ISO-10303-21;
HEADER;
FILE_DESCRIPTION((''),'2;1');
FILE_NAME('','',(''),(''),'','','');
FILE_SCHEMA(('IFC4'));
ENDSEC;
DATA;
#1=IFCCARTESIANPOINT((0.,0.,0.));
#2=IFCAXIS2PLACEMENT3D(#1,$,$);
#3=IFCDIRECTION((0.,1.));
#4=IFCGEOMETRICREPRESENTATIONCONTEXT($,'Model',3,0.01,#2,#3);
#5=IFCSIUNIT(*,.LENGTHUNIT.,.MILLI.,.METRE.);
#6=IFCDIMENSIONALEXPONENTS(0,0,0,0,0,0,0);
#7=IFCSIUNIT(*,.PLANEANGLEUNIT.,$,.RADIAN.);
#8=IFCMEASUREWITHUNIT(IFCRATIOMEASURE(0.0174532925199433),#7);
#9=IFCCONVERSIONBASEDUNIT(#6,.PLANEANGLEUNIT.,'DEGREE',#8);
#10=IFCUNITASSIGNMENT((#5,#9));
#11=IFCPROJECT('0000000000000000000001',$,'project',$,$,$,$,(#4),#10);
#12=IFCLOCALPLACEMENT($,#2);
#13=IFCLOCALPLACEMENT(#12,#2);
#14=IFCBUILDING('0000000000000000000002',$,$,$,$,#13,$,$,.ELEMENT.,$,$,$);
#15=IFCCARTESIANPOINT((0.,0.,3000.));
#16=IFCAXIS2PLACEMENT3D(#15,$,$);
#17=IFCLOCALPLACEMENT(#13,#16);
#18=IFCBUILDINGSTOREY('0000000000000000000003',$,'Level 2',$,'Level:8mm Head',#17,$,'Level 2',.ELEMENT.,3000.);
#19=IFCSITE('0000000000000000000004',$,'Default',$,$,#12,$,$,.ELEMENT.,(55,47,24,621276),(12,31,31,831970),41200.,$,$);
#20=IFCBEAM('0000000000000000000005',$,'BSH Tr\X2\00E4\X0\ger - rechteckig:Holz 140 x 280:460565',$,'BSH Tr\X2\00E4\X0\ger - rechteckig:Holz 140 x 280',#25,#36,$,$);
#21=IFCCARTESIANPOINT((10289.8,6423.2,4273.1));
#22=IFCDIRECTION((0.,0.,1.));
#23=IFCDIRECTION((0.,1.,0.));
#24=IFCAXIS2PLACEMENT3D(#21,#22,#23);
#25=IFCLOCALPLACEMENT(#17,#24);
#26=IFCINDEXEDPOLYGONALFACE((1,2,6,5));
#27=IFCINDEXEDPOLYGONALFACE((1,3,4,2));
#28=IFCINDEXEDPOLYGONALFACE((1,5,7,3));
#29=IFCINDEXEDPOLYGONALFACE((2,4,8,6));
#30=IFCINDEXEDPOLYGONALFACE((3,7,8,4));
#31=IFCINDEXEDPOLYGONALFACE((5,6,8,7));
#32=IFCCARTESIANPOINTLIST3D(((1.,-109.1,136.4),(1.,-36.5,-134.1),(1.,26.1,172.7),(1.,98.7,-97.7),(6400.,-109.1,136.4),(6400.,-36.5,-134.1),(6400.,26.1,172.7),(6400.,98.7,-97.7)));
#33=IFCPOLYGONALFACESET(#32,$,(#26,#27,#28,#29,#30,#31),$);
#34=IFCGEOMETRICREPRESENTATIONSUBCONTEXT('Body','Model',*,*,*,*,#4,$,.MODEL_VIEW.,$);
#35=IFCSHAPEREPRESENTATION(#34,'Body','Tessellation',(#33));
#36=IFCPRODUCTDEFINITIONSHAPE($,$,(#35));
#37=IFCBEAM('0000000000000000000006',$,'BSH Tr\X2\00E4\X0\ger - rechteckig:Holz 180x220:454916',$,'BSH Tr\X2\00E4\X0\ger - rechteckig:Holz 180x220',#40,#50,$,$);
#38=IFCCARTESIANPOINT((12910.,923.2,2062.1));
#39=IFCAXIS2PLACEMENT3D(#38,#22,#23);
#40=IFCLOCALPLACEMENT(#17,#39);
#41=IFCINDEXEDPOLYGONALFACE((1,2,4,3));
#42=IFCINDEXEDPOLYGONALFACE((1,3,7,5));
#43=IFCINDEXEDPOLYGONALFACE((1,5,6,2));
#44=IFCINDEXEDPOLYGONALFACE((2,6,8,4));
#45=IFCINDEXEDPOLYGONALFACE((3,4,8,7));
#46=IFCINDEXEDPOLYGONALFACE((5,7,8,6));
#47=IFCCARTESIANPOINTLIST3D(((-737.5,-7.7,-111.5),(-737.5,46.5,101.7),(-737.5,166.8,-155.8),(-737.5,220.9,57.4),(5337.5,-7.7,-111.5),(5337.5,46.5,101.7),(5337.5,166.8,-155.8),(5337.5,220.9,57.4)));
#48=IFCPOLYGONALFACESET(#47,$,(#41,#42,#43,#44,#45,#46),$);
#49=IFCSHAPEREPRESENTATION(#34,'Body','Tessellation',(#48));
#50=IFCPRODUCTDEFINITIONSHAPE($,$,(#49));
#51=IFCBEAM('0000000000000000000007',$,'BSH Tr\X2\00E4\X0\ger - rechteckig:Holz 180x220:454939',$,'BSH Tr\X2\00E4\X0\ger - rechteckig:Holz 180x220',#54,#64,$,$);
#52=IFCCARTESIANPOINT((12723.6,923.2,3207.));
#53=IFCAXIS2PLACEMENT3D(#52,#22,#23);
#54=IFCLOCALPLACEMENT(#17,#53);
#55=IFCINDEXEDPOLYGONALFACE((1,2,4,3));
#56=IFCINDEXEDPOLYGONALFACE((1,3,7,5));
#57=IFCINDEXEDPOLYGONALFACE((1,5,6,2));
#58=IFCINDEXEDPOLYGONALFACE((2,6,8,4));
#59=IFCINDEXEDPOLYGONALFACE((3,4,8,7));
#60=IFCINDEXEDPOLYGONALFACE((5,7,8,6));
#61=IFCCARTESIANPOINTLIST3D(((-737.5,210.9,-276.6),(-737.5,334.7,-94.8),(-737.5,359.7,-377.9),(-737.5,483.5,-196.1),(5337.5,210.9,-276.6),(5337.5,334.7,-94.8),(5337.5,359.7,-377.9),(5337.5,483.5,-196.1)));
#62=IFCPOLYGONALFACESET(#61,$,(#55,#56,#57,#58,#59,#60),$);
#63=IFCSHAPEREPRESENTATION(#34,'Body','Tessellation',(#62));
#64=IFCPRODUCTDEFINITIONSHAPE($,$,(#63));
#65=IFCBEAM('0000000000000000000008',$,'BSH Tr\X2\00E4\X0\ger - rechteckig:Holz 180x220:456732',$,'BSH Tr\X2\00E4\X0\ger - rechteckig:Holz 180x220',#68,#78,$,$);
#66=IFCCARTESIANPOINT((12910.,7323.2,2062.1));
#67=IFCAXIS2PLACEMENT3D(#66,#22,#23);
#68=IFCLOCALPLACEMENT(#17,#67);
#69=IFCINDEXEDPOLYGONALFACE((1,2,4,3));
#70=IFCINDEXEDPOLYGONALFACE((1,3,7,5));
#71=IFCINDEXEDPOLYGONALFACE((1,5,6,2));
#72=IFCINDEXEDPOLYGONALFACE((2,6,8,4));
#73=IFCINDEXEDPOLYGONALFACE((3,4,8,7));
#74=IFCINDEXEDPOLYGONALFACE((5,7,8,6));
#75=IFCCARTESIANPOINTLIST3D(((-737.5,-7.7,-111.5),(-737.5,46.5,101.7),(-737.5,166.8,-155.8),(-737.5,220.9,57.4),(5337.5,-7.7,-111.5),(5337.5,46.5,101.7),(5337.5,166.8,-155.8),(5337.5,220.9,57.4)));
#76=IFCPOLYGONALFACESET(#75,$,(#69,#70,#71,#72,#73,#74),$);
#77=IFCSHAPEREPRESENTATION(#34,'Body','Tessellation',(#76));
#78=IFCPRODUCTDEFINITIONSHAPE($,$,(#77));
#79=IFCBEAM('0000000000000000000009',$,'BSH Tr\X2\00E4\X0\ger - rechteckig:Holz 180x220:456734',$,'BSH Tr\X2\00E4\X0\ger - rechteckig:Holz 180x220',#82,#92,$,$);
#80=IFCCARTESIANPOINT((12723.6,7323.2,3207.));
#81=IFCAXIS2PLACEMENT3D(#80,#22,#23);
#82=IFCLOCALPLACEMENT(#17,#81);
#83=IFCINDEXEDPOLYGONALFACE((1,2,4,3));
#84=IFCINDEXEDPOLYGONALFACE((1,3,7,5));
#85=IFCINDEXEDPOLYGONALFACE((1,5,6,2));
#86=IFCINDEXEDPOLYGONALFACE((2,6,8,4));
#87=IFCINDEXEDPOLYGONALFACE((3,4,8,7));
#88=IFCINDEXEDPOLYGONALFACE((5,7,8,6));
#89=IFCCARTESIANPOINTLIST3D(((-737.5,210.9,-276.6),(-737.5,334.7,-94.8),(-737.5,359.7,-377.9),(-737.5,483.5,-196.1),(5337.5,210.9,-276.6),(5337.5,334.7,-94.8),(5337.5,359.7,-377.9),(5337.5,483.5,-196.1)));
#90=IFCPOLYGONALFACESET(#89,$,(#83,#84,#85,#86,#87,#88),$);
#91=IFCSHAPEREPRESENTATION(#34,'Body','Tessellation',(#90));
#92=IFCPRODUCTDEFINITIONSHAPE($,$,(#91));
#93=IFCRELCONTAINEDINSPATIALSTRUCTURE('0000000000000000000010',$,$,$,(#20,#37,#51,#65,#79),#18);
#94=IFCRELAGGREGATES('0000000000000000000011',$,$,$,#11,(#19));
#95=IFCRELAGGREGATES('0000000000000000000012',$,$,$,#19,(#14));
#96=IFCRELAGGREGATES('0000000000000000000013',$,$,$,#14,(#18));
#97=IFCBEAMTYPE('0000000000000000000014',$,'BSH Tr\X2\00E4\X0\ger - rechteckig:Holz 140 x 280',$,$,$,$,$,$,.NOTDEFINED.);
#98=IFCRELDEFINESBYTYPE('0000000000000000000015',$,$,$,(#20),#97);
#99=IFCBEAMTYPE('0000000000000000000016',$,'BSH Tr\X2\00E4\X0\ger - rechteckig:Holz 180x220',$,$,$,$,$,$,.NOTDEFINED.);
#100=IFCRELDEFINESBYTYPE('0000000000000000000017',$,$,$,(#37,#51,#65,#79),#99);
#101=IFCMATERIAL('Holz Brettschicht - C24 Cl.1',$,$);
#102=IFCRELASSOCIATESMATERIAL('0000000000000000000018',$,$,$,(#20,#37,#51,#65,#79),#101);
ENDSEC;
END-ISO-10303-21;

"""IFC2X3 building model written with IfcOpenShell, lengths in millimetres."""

from ifc_helpers import new_model, entity, si_unit, converted_unit, direction, frame, frame_2d, origin, place, context, subcontext, project, spatial, rectangle, extrude, material, type_object, element, save


model = new_model("IFC2X3")

# Units and contexts
model_context = context("Model", 3, precision=0.01, world=origin(), true_north=direction((0.0, 1.0)))
body_context = subcontext(model_context, "Body", "Model", "MODEL_VIEW")
ifc_project = project(units=[si_unit("LENGTHUNIT", "METRE", prefix="MILLI"), converted_unit("PLANEANGLEUNIT", "DEGREE", entity("IfcRatioMeasure", 0.0174532925199433), si_unit("PLANEANGLEUNIT", "RADIAN"), dimensions=[0, 0, 0, 0, 0, 0, 0])], contexts=[model_context])

# Site, building, storey
site_placement = place(None, origin())
site = spatial("IfcSite", under=ifc_project, at=site_placement, Name="Default", CompositionType="ELEMENT", RefLatitude=(55, 47, 24, 621276), RefLongitude=(12, 31, 31, 831970), RefElevation=41200.0)
building_placement = place(site_placement, origin())
building = spatial("IfcBuilding", under=site, at=building_placement, CompositionType="ELEMENT")
storey_placement = place(building_placement, frame((0.0, 0.0, 3000.0)))
storey = spatial("IfcBuildingStorey", under=building, at=storey_placement, Name="Level 2", ObjectType="Level:8mm Head", LongName="Level 2", CompositionType="ELEMENT", Elevation=3000.0)

# Beams
ifc_material_1 = material(Name="Holz Brettschicht - C24 Cl.1")
beam_type_1 = type_object("IfcBeamType", Name="BSH Träger - rechteckig:Holz 140 x 280", PredefinedType="NOTDEFINED")
beam_1_placement = place(storey_placement, frame((10289.8, 6423.2, 4273.1), z_axis=(0.0, 0.0, 1.0), x_axis=(0.0, 1.0, 0.0)))
element("IfcBeam", 1, at=beam_1_placement, inside=storey, type_object=beam_type_1, material=ifc_material_1, Name="BSH Träger - rechteckig:Holz 140 x 280:460565", ObjectType="BSH Träger - rechteckig:Holz 140 x 280", context=body_context, shape_type="SweptSolid", body=[
    extrude(rectangle(XDim=280.0, YDim=140.0, at=frame_2d((0.0, 0.0), x_axis=(1.0, 0.0))), frame((1.0, -5.2, 19.3), z_axis=(1.0, 0.0, 0.0), x_axis=(0.0, -0.259528, 0.965735)), (0.0, 0.0, 1.0), 6399.0),
])
beam_type_2 = type_object("IfcBeamType", Name="BSH Träger - rechteckig:Holz 180x220", PredefinedType="NOTDEFINED")
beam_2_placement = place(storey_placement, frame((12910.0, 923.2, 2062.1), z_axis=(0.0, 0.0, 1.0), x_axis=(0.0, 1.0, 0.0)))
element("IfcBeam", 2, at=beam_2_placement, inside=storey, type_object=beam_type_2, material=ifc_material_1, Name="BSH Träger - rechteckig:Holz 180x220:454916", ObjectType="BSH Träger - rechteckig:Holz 180x220", context=body_context, shape_type="SweptSolid", body=[
    extrude(rectangle(XDim=220.0, YDim=180.0, at=frame_2d((0.0, 0.0), x_axis=(1.0, 0.0))), frame((-737.5, 106.6, -27.1), z_axis=(1.0, 0.0, 0.0), x_axis=(0.0, 0.246135, 0.969236)), (0.0, 0.0, 1.0), 6075.0),
])
beam_3_placement = place(storey_placement, frame((12723.6, 923.2, 3207.0), z_axis=(0.0, 0.0, 1.0), x_axis=(0.0, 1.0, 0.0)))
element("IfcBeam", 3, at=beam_3_placement, inside=storey, type_object=beam_type_2, material=ifc_material_1, Name="BSH Träger - rechteckig:Holz 180x220:454939", ObjectType="BSH Träger - rechteckig:Holz 180x220", context=body_context, shape_type="SweptSolid", body=[
    extrude(rectangle(XDim=220.0, YDim=180.0, at=frame_2d((0.0, 0.0), x_axis=(1.0, 0.0))), frame((-737.5, 347.2, -236.4), z_axis=(1.0, 0.0, 0.0), x_axis=(0.0, 0.562789, 0.826601)), (0.0, 0.0, 1.0), 6075.0),
])
beam_4_placement = place(storey_placement, frame((12910.0, 7323.2, 2062.1), z_axis=(0.0, 0.0, 1.0), x_axis=(0.0, 1.0, 0.0)))
element("IfcBeam", 4, at=beam_4_placement, inside=storey, type_object=beam_type_2, material=ifc_material_1, Name="BSH Träger - rechteckig:Holz 180x220:456732", ObjectType="BSH Träger - rechteckig:Holz 180x220", context=body_context, shape_type="SweptSolid", body=[
    extrude(rectangle(XDim=220.0, YDim=180.0, at=frame_2d((0.0, 0.0), x_axis=(1.0, 0.0))), frame((-737.5, 106.6, -27.1), z_axis=(1.0, 0.0, 0.0), x_axis=(0.0, 0.246135, 0.969236)), (0.0, 0.0, 1.0), 6075.0),
])
beam_5_placement = place(storey_placement, frame((12723.6, 7323.2, 3207.0), z_axis=(0.0, 0.0, 1.0), x_axis=(0.0, 1.0, 0.0)))
element("IfcBeam", 5, at=beam_5_placement, inside=storey, type_object=beam_type_2, material=ifc_material_1, Name="BSH Träger - rechteckig:Holz 180x220:456734", ObjectType="BSH Träger - rechteckig:Holz 180x220", context=body_context, shape_type="SweptSolid", body=[
    extrude(rectangle(XDim=220.0, YDim=180.0, at=frame_2d((0.0, 0.0), x_axis=(1.0, 0.0))), frame((-737.5, 347.2, -236.4), z_axis=(1.0, 0.0, 0.0), x_axis=(0.0, 0.562789, 0.826601)), (0.0, 0.0, 1.0), 6075.0),
])

save(model, "model.ifc")
